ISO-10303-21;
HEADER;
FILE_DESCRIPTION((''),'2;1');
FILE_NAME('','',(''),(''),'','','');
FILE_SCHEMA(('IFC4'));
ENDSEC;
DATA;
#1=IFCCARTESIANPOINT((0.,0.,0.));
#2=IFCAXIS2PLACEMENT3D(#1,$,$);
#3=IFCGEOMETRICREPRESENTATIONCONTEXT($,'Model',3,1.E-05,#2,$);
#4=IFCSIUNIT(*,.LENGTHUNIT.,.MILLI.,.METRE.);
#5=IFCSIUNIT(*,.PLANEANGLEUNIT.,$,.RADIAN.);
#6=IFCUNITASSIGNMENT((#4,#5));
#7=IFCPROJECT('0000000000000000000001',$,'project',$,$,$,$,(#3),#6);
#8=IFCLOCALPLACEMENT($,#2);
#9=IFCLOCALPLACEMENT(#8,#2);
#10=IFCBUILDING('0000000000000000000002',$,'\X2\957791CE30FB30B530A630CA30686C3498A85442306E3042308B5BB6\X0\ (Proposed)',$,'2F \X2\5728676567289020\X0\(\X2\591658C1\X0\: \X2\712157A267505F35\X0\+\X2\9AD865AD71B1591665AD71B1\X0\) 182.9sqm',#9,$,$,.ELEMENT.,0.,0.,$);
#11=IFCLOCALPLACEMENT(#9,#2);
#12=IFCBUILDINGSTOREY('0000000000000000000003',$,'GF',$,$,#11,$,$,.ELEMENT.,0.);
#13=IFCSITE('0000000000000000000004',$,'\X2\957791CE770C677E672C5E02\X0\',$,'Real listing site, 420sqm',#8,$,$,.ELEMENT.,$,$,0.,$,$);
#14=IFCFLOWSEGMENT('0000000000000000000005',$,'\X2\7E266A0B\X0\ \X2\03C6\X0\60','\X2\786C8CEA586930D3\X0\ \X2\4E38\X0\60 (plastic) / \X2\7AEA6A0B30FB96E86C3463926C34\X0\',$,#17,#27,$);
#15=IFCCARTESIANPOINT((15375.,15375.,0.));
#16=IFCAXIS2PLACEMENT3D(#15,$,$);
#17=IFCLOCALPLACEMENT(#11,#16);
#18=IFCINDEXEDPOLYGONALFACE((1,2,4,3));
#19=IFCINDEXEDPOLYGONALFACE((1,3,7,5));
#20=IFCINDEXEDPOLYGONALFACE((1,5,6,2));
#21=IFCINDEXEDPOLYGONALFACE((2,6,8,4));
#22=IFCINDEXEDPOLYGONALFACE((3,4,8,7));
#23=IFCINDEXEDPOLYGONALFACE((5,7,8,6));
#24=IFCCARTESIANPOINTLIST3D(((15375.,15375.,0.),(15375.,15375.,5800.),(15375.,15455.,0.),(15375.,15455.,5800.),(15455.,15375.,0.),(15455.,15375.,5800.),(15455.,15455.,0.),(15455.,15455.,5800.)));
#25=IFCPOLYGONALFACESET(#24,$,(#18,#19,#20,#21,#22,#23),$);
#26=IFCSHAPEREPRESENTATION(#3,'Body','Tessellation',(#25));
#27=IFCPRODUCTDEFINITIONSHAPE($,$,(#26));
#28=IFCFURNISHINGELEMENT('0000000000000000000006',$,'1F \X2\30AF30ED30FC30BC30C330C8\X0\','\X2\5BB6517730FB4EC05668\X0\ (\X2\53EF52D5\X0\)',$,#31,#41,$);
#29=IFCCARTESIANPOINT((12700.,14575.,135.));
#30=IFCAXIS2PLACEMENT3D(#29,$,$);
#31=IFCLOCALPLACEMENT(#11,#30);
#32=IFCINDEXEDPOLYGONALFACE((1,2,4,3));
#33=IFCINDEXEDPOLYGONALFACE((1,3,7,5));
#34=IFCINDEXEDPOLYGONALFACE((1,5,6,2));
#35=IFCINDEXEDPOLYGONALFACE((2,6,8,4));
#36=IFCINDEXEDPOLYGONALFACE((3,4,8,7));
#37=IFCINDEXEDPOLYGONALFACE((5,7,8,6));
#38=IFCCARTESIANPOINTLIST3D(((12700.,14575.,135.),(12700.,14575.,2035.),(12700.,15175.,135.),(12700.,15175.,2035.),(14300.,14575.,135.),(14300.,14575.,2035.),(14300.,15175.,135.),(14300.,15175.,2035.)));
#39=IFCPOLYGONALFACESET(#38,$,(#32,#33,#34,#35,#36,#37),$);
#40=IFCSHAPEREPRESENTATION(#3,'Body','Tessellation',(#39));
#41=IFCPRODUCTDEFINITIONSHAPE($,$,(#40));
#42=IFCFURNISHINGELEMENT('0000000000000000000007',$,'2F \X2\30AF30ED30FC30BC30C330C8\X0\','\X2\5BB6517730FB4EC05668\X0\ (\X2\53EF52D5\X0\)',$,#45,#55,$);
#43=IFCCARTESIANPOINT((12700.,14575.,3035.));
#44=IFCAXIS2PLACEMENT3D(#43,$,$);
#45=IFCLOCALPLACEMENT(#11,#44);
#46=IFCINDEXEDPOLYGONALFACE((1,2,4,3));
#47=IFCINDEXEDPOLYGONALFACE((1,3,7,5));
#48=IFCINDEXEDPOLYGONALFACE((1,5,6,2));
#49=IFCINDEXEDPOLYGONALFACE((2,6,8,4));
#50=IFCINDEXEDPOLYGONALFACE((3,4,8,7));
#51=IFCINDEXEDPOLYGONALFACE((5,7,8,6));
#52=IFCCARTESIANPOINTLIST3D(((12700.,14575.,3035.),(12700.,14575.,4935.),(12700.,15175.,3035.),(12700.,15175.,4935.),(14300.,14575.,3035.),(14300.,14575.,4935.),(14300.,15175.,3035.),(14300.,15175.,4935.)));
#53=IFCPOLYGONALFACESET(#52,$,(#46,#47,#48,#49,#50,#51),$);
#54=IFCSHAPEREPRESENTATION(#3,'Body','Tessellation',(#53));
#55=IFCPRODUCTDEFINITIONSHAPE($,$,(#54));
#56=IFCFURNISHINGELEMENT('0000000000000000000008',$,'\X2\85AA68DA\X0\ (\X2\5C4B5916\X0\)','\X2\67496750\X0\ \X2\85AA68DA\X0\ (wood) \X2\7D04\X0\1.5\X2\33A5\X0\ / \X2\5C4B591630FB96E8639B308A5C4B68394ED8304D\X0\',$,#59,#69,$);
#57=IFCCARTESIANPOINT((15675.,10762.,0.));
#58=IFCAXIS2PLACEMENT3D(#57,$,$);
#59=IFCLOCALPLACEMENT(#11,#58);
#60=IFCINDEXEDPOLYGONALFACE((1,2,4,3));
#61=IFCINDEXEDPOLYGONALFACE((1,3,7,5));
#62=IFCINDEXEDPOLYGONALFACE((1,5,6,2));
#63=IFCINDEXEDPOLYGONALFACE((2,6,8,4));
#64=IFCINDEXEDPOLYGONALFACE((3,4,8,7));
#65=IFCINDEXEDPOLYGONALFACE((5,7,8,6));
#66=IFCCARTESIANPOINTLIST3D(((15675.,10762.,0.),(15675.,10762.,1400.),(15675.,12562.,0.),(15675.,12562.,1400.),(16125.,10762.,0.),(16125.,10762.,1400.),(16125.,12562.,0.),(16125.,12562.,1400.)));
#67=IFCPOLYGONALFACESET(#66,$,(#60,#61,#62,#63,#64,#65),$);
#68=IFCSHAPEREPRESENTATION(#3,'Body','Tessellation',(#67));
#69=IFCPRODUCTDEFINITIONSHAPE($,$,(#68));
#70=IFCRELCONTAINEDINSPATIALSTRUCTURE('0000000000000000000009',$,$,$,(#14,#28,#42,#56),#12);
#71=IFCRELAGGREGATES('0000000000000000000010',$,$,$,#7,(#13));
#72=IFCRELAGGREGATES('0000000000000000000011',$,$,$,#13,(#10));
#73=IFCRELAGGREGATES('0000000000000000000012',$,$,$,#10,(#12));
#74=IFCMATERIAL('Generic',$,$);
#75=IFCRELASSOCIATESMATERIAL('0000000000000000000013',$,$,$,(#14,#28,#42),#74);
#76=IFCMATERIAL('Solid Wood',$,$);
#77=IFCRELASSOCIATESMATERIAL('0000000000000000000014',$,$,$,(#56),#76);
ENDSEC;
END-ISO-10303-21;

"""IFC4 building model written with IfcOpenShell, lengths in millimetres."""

from ifc_helpers import new_model, si_unit, frame, frame_2d, origin, place, context, project, spatial, rectangle, extrude, material, element, save


model = new_model("IFC4")

# Units and contexts
model_context = context("Model", 3, precision=1e-05, world=origin())
ifc_project = project(units=[si_unit("LENGTHUNIT", "METRE", prefix="MILLI"), si_unit("PLANEANGLEUNIT", "RADIAN")], contexts=[model_context])

# Site, building, storey
site_placement = place(None, origin())
site = spatial("IfcSite", under=ifc_project, at=site_placement, Name="長野県松本市", ObjectType="Real listing site, 420sqm", CompositionType="ELEMENT", RefElevation=0.0)
building_placement = place(site_placement, origin())
building = spatial("IfcBuilding", under=site, at=building_placement, Name="長野・サウナと水風呂のある家 (Proposed)", ObjectType="2F 在来木造(外壁: 無垢材張+高断熱外断熱) 182.9sqm", CompositionType="ELEMENT", ElevationOfRefHeight=0.0, ElevationOfTerrain=0.0)
storey_placement = place(building_placement, origin())
storey = spatial("IfcBuildingStorey", under=building, at=storey_placement, Name="GF", CompositionType="ELEMENT", Elevation=0.0)

# Shared definitions
ifc_material_1 = material(Name="Solid Wood")

# Shared definitions
ifc_material_2 = material(Name="Generic")

# Flow segment
flow_segment_placement = place(storey_placement, frame((15375.0, 15375.0, 0.0)))
element("IfcFlowSegment", 1, at=flow_segment_placement, inside=storey, material=ifc_material_2, Name="縦樋 φ60", Description="硬質塩ビ 丸60 (plastic) / 竪樋・雨水排水", context=model_context, shape_type="SweptSolid", body=[
    extrude(rectangle(XDim=80.0, YDim=80.0, at=frame_2d((40.0, 40.0))), frame((15375.0, 15375.0, 0.0)), (0.0, 0.0, 1.0), 5800.0),
])

# Furnishing elements
furnishing_1_placement = place(storey_placement, frame((12700.0, 14575.0, 135.0)))
element("IfcFurnishingElement", 2, at=furnishing_1_placement, inside=storey, material=ifc_material_2, Name="1F クローゼット", Description="家具・什器 (可動)", context=model_context, shape_type="SweptSolid", body=[
    extrude(rectangle(XDim=1600.0, YDim=600.0, at=frame_2d((800.0, 300.0))), frame((12700.0, 14575.0, 135.0)), (0.0, 0.0, 1.0), 1900.0),
])
furnishing_2_placement = place(storey_placement, frame((12700.0, 14575.0, 3035.0)))
element("IfcFurnishingElement", 3, at=furnishing_2_placement, inside=storey, material=ifc_material_2, Name="2F クローゼット", Description="家具・什器 (可動)", context=model_context, shape_type="SweptSolid", body=[
    extrude(rectangle(XDim=1600.0, YDim=600.0, at=frame_2d((800.0, 300.0))), frame((12700.0, 14575.0, 3035.0)), (0.0, 0.0, 1.0), 1900.0),
])
furnishing_3_placement = place(storey_placement, frame((15675.0, 10762.0, 0.0)))
element("IfcFurnishingElement", 4, at=furnishing_3_placement, inside=storey, material=ifc_material_1, Name="薪棚 (屋外)", Description="杉材 薪棚 (wood) 約1.5㎥ / 屋外・雨掛り屋根付き", context=model_context, shape_type="SweptSolid", body=[
    extrude(rectangle(XDim=450.0, YDim=1800.0, at=frame_2d((225.0, 900.0))), frame((15675.0, 10762.0, 0.0)), (0.0, 0.0, 1.0), 1400.0),
])

save(model, "model.ifc")
